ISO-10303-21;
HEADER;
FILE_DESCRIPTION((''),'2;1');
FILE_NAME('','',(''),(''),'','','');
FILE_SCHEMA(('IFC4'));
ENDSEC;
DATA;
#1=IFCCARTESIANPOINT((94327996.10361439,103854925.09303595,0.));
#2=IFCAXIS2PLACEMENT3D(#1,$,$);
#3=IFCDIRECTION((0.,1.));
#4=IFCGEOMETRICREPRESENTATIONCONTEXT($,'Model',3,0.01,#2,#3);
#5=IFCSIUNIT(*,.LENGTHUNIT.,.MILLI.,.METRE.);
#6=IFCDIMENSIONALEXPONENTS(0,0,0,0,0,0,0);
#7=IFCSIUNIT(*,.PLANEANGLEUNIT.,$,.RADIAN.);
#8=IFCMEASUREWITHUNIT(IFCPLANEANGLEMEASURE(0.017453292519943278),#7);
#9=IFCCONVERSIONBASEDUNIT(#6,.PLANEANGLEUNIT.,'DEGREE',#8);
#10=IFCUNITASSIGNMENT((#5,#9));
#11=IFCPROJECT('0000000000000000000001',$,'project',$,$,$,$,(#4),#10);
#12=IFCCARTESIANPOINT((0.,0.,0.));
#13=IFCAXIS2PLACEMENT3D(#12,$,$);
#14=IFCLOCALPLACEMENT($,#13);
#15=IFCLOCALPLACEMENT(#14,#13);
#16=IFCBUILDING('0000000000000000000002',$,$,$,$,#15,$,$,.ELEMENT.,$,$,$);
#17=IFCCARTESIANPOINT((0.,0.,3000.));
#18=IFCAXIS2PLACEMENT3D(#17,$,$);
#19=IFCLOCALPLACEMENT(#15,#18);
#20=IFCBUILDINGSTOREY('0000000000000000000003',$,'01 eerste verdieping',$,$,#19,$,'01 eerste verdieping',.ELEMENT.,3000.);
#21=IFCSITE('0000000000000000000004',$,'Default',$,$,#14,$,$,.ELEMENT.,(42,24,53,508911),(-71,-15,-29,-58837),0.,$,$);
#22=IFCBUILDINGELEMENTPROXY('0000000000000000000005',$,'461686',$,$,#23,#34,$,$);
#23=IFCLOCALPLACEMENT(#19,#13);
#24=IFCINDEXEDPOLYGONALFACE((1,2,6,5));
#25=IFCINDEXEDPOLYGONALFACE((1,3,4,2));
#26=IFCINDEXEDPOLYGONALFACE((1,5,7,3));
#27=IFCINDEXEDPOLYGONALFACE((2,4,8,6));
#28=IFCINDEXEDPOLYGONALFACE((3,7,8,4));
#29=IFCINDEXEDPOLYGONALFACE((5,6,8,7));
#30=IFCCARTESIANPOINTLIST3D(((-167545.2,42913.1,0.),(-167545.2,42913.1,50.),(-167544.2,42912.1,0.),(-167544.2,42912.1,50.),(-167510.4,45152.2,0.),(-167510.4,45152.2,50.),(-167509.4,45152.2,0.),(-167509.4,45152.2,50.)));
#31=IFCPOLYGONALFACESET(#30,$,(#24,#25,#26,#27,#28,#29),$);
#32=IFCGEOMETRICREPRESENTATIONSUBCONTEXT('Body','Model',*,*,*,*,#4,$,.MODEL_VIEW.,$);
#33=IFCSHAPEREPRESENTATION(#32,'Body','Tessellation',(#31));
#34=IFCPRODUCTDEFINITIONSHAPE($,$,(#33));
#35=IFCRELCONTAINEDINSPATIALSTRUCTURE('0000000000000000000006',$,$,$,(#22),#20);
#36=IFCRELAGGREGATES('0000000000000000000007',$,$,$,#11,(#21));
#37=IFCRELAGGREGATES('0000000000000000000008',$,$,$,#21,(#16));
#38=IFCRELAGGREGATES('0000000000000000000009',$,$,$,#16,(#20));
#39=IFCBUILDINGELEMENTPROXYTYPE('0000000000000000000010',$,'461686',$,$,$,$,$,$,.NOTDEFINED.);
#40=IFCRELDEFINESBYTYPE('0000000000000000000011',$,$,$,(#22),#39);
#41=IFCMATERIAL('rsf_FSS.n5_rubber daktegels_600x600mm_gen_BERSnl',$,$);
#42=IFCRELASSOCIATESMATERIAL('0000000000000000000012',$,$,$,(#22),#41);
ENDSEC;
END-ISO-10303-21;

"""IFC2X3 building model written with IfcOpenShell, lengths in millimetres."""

from ifc_helpers import new_model, entity, si_unit, converted_unit, direction, frame, origin, place, context, subcontext, project, spatial, polyline, outline, extrude, material, type_object, element, save


model = new_model("IFC2X3")

# Units and contexts
model_context = context("Model", 3, precision=0.01, world=frame((94327996.10361439, 103854925.09303595, 0.0)), true_north=direction((0.0, 1.0)))
body_context = subcontext(model_context, "Body", "Model", "MODEL_VIEW")
ifc_project = project(units=[si_unit("LENGTHUNIT", "METRE", prefix="MILLI"), converted_unit("PLANEANGLEUNIT", "DEGREE", entity("IfcPlaneAngleMeasure", 0.017453292519943278), si_unit("PLANEANGLEUNIT", "RADIAN"), dimensions=[0, 0, 0, 0, 0, 0, 0])], contexts=[model_context])

# Site, building, storey
site_placement = place(None, origin())
site = spatial("IfcSite", under=ifc_project, at=site_placement, Name="Default", CompositionType="ELEMENT", RefLatitude=(42, 24, 53, 508911), RefLongitude=(-71, -15, -29, -58837), RefElevation=0.0)
building_placement = place(site_placement, origin())
building = spatial("IfcBuilding", under=site, at=building_placement, CompositionType="ELEMENT")
storey_placement = place(building_placement, frame((0.0, 0.0, 3000.0)))
storey = spatial("IfcBuildingStorey", under=building, at=storey_placement, Name="01 eerste verdieping", LongName="01 eerste verdieping", CompositionType="ELEMENT", Elevation=3000.0)

# Building element proxy
ifc_material = material(Name="rsf_FSS.n5_rubber daktegels_600x600mm_gen_BERSnl")
building_element_proxy_type_1 = type_object("IfcBuildingElementProxyType", Name="461686", PredefinedType="NOTDEFINED")
proxy_1_placement = place(storey_placement, origin())
element("IfcBuildingElementProxy", 1, at=proxy_1_placement, inside=storey, type_object=building_element_proxy_type_1, material=ifc_material, Name="461686", context=body_context, shape_type="SweptSolid", body=[
    extrude(outline(polyline([(-1120.0, -0.5), (1119.5, -0.5), (1120.5, 0.5), (-1120.0, 0.5), (-1120.0, -0.5)])), frame((-167527.3, 44032.4, 0.0), z_axis=(0.0, 0.0, 1.0), x_axis=(-0.015554, -0.999879, 0.0)), (0.0, 0.0, 1.0), 50.0),
])

save(model, "model.ifc")
